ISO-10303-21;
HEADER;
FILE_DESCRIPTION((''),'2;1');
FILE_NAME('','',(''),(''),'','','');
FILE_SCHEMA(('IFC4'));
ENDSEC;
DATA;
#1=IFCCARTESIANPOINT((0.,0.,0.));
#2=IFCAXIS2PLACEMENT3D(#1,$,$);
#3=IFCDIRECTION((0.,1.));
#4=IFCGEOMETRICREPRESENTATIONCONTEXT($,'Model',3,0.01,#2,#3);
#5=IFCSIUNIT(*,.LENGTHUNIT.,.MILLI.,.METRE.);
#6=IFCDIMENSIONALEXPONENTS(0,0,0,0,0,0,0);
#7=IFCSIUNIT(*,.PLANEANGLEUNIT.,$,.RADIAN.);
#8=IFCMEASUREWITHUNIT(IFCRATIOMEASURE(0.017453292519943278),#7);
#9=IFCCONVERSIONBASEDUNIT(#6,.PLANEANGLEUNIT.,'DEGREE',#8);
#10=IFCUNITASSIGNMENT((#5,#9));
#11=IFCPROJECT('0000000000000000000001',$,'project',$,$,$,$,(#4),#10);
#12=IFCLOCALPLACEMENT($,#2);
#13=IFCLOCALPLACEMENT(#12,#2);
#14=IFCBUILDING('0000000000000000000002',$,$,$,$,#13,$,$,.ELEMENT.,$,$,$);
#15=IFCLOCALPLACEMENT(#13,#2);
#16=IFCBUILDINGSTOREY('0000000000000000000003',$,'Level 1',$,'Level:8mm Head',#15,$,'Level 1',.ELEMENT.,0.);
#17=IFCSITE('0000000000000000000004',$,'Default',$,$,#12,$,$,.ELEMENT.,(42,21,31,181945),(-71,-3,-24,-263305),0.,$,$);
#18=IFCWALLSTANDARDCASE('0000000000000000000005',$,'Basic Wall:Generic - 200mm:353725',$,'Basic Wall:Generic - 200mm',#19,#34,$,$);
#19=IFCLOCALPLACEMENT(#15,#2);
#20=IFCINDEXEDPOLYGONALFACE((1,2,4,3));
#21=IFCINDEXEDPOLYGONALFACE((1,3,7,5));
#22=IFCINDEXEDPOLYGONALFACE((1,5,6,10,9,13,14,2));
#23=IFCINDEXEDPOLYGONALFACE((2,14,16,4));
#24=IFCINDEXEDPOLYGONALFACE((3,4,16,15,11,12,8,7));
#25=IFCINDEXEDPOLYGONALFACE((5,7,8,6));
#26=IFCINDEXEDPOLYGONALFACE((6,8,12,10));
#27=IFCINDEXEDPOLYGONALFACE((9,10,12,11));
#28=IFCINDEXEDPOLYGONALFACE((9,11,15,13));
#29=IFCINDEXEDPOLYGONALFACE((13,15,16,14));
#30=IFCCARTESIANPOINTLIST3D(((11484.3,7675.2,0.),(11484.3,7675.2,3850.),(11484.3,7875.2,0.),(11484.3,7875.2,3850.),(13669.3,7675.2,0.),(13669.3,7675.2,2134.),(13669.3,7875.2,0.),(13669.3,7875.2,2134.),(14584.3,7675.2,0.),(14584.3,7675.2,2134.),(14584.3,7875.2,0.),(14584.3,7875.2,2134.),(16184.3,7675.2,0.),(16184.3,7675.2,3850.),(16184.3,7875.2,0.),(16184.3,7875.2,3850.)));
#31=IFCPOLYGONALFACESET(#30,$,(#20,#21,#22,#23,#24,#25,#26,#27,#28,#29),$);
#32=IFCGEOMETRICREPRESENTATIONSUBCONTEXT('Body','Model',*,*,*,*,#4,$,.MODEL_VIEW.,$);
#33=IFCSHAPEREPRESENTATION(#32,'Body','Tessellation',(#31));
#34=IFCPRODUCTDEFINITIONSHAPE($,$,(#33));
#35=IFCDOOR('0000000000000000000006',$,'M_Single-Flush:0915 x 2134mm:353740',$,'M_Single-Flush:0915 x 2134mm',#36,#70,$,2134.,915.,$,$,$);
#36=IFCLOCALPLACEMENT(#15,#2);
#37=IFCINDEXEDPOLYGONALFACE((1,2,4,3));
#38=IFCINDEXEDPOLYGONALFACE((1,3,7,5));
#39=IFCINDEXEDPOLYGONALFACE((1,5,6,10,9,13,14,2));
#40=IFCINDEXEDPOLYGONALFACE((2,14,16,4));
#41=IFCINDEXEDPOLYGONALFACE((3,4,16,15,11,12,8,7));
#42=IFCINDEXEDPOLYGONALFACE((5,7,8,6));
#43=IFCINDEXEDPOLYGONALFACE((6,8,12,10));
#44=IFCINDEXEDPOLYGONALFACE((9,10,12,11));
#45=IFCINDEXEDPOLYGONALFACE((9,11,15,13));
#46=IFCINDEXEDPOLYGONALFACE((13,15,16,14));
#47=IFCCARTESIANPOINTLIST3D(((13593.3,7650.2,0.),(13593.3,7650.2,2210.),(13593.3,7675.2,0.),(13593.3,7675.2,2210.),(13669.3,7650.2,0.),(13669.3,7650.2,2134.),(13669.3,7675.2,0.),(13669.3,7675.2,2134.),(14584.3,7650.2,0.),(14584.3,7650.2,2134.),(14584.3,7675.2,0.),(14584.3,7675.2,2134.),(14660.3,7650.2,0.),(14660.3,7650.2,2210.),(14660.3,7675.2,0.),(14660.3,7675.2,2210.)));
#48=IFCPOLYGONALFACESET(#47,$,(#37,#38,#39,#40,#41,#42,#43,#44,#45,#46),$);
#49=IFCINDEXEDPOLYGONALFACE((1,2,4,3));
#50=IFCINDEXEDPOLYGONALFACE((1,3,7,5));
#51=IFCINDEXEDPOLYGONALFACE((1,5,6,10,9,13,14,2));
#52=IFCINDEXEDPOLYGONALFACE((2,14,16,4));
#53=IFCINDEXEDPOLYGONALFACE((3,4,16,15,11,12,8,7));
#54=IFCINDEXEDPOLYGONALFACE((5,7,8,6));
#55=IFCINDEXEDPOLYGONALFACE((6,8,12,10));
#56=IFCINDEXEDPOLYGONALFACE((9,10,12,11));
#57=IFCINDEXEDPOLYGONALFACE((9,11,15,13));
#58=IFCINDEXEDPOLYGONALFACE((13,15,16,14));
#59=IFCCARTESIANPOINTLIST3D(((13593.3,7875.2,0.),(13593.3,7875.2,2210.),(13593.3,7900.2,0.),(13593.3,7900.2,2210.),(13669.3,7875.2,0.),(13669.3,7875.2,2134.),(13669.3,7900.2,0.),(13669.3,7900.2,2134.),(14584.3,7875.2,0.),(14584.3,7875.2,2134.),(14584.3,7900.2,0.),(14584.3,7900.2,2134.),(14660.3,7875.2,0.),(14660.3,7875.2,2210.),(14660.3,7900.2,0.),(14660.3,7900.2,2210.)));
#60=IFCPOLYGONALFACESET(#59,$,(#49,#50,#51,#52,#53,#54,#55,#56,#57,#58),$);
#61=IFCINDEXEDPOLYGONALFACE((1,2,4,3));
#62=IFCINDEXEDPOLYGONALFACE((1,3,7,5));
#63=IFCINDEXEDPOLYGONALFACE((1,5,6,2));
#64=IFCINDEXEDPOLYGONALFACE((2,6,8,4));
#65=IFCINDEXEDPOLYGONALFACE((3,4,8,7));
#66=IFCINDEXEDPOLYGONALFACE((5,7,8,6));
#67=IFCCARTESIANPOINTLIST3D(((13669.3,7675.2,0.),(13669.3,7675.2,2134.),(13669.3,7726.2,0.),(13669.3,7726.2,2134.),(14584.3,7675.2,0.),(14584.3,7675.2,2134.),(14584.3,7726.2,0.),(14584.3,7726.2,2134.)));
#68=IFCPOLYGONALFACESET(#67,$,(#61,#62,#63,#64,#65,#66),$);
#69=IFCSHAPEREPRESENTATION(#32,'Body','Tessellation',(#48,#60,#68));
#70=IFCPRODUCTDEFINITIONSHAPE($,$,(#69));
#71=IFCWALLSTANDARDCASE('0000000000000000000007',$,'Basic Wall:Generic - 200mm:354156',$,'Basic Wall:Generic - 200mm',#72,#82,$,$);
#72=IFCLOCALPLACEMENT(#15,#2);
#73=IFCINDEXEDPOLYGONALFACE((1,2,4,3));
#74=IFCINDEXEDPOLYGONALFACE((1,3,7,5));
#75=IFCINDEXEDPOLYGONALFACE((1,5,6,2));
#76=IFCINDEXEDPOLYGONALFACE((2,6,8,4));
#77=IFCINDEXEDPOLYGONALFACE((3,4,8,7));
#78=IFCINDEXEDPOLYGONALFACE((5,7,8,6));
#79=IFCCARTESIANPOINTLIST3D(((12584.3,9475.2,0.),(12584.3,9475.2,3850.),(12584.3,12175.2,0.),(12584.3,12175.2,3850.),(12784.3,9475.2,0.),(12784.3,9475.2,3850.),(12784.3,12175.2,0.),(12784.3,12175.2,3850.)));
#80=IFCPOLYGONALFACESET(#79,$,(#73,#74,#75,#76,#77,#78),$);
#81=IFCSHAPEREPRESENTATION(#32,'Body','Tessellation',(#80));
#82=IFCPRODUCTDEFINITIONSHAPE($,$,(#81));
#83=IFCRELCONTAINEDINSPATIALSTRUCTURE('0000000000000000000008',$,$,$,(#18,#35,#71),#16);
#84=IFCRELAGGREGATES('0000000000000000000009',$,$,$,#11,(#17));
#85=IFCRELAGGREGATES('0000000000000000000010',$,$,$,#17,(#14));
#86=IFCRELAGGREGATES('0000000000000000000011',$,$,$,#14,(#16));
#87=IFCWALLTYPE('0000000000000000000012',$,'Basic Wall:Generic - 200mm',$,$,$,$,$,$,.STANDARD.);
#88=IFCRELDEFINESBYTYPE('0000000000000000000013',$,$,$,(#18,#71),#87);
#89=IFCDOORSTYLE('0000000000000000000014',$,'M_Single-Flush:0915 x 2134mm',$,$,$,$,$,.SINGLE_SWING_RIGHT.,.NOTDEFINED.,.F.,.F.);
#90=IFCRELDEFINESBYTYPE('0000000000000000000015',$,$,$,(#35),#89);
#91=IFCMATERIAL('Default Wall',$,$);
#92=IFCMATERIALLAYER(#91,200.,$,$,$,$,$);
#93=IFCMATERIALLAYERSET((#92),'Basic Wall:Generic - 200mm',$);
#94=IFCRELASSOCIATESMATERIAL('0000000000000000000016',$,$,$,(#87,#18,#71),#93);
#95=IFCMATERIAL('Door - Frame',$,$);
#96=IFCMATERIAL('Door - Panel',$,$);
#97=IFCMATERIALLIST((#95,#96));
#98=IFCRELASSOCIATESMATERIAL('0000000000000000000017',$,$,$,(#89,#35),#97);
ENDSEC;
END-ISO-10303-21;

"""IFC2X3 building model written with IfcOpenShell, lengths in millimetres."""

from ifc_helpers import new_model, entity, si_unit, converted_unit, direction, frame, frame_2d, origin, place, context, subcontext, project, spatial, polyline, rectangle, outline, extrude, clip, bounded_halfspace, source, transform, mapped, material, material_list, layer, layer_set, layer_usage, type_object, type_shapes, element, fill, save


model = new_model("IFC2X3")

# Units and contexts
model_context = context("Model", 3, precision=0.01, world=origin(), true_north=direction((0.0, 1.0)))
body_context = subcontext(model_context, "Body", "Model", "MODEL_VIEW")
ifc_project = project(units=[si_unit("LENGTHUNIT", "METRE", prefix="MILLI"), converted_unit("PLANEANGLEUNIT", "DEGREE", entity("IfcRatioMeasure", 0.017453292519943278), si_unit("PLANEANGLEUNIT", "RADIAN"), dimensions=[0, 0, 0, 0, 0, 0, 0])], contexts=[model_context])

# Site, building, storey
site_placement = place(None, origin())
site = spatial("IfcSite", under=ifc_project, at=site_placement, Name="Default", CompositionType="ELEMENT", RefLatitude=(42, 21, 31, 181945), RefLongitude=(-71, -3, -24, -263305), RefElevation=0.0)
building_placement = place(site_placement, origin())
building = spatial("IfcBuilding", under=site, at=building_placement, CompositionType="ELEMENT")
storey_placement = place(building_placement, origin())
storey = spatial("IfcBuildingStorey", under=building, at=storey_placement, Name="Level 1", ObjectType="Level:8mm Head", LongName="Level 1", CompositionType="ELEMENT", Elevation=0.0)

# Shared definitions
ifc_material_1 = material(Name="Default Wall")
ifc_layer_1 = layer(ifc_material_1, 200.0)
ifc_layer_set_1 = layer_set([ifc_layer_1], Name="Basic Wall:Generic - 200mm")
ifc_layer_usage_1 = layer_usage(ifc_layer_set_1, "AXIS2", "NEGATIVE", 100.0)
wall_type = type_object("IfcWallType", Name="Basic Wall:Generic - 200mm", PredefinedType="STANDARD", material=ifc_layer_set_1)

# Shared definitions
ifc_material_2 = material(Name="Door - Frame")
ifc_material_3 = material(Name="Door - Panel")
ifc_material_list = material_list([ifc_material_2, ifc_material_3])
door_style = type_object("IfcDoorStyle", Name="M_Single-Flush:0915 x 2134mm", ConstructionType="NOTDEFINED", OperationType="SINGLE_SWING_RIGHT", ParameterTakesPrecedence=False, Sizeable=False, material=ifc_material_list)
shared_shape = source(origin(), body_context, "Body", "SweptSolid", [
    extrude(outline(polyline([(-533.5, -1124.0), (533.5, -1124.0), (533.5, 1086.0), (457.5, 1086.0), (457.5, -1048.0), (-457.5, -1048.0), (-457.5, 1086.0), (-533.5, 1086.0), (-533.5, -1124.0)])), frame((457.5, 200.0, 1086.0), z_axis=(0.0, 1.0, 0.0), x_axis=(1.0, 0.0, 0.0)), (0.0, 0.0, 1.0), 25.0),
    extrude(outline(polyline([(-1124.0, -533.5), (1086.0, -533.5), (1086.0, -457.5), (-1048.0, -457.5), (-1048.0, 457.5), (1086.0, 457.5), (1086.0, 533.5), (-1124.0, 533.5), (-1124.0, -533.5)])), frame((457.5, -25.0, 1086.0), z_axis=(0.0, 1.0, 0.0), x_axis=(0.0, 0.0, -1.0)), (0.0, 0.0, 1.0), 25.0),
    extrude(rectangle(XDim=51.0, YDim=915.0, at=frame_2d((0.0, 0.0), x_axis=(1.0, 0.0))), frame((457.5, 174.5, 0.0), z_axis=(0.0, 0.0, 1.0), x_axis=(0.0, 1.0, 0.0)), (0.0, 0.0, 1.0), 2134.0),
])
type_shapes(door_style, [shared_shape])

# Wall, opening, door
wall_1_placement = place(storey_placement, frame((11484.3, 7775.2, 0.0)))
wall_1 = element("IfcWallStandardCase", 1, at=wall_1_placement, inside=storey, type_object=wall_type, material=ifc_layer_usage_1, Name="Basic Wall:Generic - 200mm:353725", ObjectType="Basic Wall:Generic - 200mm", context=body_context, shape_type="Clipping", body=[
    clip(extrude(rectangle(XDim=4700.0, YDim=200.0, at=frame_2d((2350.0, 0.0), x_axis=(1.0, 0.0))), origin(), (0.0, 0.0, 1.0), 3850.0), bounded_halfspace(frame((0.0, -100.0, 3850.0), z_axis=(0.0, 0.0, -1.0), x_axis=(1.0, 0.0, 0.0)), True, frame((0.0, -100.0, 3850.0)), polyline([(0.0, 0.0), (4700.0, 0.0), (4700.0, 200.0), (0.0, 200.0), (0.0, 0.0)]))),
])
opening_1_placement = place(wall_1_placement, frame((3100.0, 100.0, 0.0)))
opening_1 = element("IfcOpeningElement", 2, at=opening_1_placement, cuts=wall_1, ObjectType="Opening", context=body_context, shape_type="SweptSolid", body=[
    extrude(rectangle(XDim=915.0, YDim=2134.0, at=frame_2d((1067.0, 457.5), x_axis=(0.0, 1.0))), frame((0.0, 0.0, 0.0), z_axis=(0.0, -1.0, 0.0), x_axis=(0.0, 0.0, 1.0)), (0.0, 0.0, 1.0), 200.0),
])
door_1_placement = place(opening_1_placement, frame((0.0, 0.0, 0.0), z_axis=(0.0, 0.0, 1.0), x_axis=(-1.0, 0.0, 0.0)))
door_1 = element("IfcDoor", 3, at=door_1_placement, inside=storey, type_object=door_style, material=ifc_material_list, Name="M_Single-Flush:0915 x 2134mm:353740", ObjectType="M_Single-Flush:0915 x 2134mm", OverallHeight=2134.0, OverallWidth=915.0, context=body_context, shape_type="MappedRepresentation", body=[
    mapped(shared_shape, transform((0.0, 0.0, 0.0), scale=1.0)),
])
fill(opening_1, door_1)

# Wall
wall_2_placement = place(storey_placement, frame((12684.3, 12175.2, 0.0), z_axis=(0.0, 0.0, 1.0), x_axis=(0.0, -1.0, 0.0)))
element("IfcWallStandardCase", 4, at=wall_2_placement, inside=storey, type_object=wall_type, material=ifc_layer_usage_1, Name="Basic Wall:Generic - 200mm:354156", ObjectType="Basic Wall:Generic - 200mm", context=body_context, shape_type="Clipping", body=[
    clip(extrude(rectangle(XDim=2700.0, YDim=200.0, at=frame_2d((1350.0, 0.0), x_axis=(-1.0, 0.0))), origin(), (0.0, 0.0, 1.0), 3850.0), bounded_halfspace(frame((0.0, -100.0, 3850.0), z_axis=(0.0, 0.0, -1.0), x_axis=(0.0, 1.0, 0.0)), True, frame((0.0, -100.0, 3850.0)), polyline([(0.0, 0.0), (2700.0, 0.0), (2700.0, 200.0), (0.0, 200.0), (0.0, 0.0)]))),
])

save(model, "model.ifc")
